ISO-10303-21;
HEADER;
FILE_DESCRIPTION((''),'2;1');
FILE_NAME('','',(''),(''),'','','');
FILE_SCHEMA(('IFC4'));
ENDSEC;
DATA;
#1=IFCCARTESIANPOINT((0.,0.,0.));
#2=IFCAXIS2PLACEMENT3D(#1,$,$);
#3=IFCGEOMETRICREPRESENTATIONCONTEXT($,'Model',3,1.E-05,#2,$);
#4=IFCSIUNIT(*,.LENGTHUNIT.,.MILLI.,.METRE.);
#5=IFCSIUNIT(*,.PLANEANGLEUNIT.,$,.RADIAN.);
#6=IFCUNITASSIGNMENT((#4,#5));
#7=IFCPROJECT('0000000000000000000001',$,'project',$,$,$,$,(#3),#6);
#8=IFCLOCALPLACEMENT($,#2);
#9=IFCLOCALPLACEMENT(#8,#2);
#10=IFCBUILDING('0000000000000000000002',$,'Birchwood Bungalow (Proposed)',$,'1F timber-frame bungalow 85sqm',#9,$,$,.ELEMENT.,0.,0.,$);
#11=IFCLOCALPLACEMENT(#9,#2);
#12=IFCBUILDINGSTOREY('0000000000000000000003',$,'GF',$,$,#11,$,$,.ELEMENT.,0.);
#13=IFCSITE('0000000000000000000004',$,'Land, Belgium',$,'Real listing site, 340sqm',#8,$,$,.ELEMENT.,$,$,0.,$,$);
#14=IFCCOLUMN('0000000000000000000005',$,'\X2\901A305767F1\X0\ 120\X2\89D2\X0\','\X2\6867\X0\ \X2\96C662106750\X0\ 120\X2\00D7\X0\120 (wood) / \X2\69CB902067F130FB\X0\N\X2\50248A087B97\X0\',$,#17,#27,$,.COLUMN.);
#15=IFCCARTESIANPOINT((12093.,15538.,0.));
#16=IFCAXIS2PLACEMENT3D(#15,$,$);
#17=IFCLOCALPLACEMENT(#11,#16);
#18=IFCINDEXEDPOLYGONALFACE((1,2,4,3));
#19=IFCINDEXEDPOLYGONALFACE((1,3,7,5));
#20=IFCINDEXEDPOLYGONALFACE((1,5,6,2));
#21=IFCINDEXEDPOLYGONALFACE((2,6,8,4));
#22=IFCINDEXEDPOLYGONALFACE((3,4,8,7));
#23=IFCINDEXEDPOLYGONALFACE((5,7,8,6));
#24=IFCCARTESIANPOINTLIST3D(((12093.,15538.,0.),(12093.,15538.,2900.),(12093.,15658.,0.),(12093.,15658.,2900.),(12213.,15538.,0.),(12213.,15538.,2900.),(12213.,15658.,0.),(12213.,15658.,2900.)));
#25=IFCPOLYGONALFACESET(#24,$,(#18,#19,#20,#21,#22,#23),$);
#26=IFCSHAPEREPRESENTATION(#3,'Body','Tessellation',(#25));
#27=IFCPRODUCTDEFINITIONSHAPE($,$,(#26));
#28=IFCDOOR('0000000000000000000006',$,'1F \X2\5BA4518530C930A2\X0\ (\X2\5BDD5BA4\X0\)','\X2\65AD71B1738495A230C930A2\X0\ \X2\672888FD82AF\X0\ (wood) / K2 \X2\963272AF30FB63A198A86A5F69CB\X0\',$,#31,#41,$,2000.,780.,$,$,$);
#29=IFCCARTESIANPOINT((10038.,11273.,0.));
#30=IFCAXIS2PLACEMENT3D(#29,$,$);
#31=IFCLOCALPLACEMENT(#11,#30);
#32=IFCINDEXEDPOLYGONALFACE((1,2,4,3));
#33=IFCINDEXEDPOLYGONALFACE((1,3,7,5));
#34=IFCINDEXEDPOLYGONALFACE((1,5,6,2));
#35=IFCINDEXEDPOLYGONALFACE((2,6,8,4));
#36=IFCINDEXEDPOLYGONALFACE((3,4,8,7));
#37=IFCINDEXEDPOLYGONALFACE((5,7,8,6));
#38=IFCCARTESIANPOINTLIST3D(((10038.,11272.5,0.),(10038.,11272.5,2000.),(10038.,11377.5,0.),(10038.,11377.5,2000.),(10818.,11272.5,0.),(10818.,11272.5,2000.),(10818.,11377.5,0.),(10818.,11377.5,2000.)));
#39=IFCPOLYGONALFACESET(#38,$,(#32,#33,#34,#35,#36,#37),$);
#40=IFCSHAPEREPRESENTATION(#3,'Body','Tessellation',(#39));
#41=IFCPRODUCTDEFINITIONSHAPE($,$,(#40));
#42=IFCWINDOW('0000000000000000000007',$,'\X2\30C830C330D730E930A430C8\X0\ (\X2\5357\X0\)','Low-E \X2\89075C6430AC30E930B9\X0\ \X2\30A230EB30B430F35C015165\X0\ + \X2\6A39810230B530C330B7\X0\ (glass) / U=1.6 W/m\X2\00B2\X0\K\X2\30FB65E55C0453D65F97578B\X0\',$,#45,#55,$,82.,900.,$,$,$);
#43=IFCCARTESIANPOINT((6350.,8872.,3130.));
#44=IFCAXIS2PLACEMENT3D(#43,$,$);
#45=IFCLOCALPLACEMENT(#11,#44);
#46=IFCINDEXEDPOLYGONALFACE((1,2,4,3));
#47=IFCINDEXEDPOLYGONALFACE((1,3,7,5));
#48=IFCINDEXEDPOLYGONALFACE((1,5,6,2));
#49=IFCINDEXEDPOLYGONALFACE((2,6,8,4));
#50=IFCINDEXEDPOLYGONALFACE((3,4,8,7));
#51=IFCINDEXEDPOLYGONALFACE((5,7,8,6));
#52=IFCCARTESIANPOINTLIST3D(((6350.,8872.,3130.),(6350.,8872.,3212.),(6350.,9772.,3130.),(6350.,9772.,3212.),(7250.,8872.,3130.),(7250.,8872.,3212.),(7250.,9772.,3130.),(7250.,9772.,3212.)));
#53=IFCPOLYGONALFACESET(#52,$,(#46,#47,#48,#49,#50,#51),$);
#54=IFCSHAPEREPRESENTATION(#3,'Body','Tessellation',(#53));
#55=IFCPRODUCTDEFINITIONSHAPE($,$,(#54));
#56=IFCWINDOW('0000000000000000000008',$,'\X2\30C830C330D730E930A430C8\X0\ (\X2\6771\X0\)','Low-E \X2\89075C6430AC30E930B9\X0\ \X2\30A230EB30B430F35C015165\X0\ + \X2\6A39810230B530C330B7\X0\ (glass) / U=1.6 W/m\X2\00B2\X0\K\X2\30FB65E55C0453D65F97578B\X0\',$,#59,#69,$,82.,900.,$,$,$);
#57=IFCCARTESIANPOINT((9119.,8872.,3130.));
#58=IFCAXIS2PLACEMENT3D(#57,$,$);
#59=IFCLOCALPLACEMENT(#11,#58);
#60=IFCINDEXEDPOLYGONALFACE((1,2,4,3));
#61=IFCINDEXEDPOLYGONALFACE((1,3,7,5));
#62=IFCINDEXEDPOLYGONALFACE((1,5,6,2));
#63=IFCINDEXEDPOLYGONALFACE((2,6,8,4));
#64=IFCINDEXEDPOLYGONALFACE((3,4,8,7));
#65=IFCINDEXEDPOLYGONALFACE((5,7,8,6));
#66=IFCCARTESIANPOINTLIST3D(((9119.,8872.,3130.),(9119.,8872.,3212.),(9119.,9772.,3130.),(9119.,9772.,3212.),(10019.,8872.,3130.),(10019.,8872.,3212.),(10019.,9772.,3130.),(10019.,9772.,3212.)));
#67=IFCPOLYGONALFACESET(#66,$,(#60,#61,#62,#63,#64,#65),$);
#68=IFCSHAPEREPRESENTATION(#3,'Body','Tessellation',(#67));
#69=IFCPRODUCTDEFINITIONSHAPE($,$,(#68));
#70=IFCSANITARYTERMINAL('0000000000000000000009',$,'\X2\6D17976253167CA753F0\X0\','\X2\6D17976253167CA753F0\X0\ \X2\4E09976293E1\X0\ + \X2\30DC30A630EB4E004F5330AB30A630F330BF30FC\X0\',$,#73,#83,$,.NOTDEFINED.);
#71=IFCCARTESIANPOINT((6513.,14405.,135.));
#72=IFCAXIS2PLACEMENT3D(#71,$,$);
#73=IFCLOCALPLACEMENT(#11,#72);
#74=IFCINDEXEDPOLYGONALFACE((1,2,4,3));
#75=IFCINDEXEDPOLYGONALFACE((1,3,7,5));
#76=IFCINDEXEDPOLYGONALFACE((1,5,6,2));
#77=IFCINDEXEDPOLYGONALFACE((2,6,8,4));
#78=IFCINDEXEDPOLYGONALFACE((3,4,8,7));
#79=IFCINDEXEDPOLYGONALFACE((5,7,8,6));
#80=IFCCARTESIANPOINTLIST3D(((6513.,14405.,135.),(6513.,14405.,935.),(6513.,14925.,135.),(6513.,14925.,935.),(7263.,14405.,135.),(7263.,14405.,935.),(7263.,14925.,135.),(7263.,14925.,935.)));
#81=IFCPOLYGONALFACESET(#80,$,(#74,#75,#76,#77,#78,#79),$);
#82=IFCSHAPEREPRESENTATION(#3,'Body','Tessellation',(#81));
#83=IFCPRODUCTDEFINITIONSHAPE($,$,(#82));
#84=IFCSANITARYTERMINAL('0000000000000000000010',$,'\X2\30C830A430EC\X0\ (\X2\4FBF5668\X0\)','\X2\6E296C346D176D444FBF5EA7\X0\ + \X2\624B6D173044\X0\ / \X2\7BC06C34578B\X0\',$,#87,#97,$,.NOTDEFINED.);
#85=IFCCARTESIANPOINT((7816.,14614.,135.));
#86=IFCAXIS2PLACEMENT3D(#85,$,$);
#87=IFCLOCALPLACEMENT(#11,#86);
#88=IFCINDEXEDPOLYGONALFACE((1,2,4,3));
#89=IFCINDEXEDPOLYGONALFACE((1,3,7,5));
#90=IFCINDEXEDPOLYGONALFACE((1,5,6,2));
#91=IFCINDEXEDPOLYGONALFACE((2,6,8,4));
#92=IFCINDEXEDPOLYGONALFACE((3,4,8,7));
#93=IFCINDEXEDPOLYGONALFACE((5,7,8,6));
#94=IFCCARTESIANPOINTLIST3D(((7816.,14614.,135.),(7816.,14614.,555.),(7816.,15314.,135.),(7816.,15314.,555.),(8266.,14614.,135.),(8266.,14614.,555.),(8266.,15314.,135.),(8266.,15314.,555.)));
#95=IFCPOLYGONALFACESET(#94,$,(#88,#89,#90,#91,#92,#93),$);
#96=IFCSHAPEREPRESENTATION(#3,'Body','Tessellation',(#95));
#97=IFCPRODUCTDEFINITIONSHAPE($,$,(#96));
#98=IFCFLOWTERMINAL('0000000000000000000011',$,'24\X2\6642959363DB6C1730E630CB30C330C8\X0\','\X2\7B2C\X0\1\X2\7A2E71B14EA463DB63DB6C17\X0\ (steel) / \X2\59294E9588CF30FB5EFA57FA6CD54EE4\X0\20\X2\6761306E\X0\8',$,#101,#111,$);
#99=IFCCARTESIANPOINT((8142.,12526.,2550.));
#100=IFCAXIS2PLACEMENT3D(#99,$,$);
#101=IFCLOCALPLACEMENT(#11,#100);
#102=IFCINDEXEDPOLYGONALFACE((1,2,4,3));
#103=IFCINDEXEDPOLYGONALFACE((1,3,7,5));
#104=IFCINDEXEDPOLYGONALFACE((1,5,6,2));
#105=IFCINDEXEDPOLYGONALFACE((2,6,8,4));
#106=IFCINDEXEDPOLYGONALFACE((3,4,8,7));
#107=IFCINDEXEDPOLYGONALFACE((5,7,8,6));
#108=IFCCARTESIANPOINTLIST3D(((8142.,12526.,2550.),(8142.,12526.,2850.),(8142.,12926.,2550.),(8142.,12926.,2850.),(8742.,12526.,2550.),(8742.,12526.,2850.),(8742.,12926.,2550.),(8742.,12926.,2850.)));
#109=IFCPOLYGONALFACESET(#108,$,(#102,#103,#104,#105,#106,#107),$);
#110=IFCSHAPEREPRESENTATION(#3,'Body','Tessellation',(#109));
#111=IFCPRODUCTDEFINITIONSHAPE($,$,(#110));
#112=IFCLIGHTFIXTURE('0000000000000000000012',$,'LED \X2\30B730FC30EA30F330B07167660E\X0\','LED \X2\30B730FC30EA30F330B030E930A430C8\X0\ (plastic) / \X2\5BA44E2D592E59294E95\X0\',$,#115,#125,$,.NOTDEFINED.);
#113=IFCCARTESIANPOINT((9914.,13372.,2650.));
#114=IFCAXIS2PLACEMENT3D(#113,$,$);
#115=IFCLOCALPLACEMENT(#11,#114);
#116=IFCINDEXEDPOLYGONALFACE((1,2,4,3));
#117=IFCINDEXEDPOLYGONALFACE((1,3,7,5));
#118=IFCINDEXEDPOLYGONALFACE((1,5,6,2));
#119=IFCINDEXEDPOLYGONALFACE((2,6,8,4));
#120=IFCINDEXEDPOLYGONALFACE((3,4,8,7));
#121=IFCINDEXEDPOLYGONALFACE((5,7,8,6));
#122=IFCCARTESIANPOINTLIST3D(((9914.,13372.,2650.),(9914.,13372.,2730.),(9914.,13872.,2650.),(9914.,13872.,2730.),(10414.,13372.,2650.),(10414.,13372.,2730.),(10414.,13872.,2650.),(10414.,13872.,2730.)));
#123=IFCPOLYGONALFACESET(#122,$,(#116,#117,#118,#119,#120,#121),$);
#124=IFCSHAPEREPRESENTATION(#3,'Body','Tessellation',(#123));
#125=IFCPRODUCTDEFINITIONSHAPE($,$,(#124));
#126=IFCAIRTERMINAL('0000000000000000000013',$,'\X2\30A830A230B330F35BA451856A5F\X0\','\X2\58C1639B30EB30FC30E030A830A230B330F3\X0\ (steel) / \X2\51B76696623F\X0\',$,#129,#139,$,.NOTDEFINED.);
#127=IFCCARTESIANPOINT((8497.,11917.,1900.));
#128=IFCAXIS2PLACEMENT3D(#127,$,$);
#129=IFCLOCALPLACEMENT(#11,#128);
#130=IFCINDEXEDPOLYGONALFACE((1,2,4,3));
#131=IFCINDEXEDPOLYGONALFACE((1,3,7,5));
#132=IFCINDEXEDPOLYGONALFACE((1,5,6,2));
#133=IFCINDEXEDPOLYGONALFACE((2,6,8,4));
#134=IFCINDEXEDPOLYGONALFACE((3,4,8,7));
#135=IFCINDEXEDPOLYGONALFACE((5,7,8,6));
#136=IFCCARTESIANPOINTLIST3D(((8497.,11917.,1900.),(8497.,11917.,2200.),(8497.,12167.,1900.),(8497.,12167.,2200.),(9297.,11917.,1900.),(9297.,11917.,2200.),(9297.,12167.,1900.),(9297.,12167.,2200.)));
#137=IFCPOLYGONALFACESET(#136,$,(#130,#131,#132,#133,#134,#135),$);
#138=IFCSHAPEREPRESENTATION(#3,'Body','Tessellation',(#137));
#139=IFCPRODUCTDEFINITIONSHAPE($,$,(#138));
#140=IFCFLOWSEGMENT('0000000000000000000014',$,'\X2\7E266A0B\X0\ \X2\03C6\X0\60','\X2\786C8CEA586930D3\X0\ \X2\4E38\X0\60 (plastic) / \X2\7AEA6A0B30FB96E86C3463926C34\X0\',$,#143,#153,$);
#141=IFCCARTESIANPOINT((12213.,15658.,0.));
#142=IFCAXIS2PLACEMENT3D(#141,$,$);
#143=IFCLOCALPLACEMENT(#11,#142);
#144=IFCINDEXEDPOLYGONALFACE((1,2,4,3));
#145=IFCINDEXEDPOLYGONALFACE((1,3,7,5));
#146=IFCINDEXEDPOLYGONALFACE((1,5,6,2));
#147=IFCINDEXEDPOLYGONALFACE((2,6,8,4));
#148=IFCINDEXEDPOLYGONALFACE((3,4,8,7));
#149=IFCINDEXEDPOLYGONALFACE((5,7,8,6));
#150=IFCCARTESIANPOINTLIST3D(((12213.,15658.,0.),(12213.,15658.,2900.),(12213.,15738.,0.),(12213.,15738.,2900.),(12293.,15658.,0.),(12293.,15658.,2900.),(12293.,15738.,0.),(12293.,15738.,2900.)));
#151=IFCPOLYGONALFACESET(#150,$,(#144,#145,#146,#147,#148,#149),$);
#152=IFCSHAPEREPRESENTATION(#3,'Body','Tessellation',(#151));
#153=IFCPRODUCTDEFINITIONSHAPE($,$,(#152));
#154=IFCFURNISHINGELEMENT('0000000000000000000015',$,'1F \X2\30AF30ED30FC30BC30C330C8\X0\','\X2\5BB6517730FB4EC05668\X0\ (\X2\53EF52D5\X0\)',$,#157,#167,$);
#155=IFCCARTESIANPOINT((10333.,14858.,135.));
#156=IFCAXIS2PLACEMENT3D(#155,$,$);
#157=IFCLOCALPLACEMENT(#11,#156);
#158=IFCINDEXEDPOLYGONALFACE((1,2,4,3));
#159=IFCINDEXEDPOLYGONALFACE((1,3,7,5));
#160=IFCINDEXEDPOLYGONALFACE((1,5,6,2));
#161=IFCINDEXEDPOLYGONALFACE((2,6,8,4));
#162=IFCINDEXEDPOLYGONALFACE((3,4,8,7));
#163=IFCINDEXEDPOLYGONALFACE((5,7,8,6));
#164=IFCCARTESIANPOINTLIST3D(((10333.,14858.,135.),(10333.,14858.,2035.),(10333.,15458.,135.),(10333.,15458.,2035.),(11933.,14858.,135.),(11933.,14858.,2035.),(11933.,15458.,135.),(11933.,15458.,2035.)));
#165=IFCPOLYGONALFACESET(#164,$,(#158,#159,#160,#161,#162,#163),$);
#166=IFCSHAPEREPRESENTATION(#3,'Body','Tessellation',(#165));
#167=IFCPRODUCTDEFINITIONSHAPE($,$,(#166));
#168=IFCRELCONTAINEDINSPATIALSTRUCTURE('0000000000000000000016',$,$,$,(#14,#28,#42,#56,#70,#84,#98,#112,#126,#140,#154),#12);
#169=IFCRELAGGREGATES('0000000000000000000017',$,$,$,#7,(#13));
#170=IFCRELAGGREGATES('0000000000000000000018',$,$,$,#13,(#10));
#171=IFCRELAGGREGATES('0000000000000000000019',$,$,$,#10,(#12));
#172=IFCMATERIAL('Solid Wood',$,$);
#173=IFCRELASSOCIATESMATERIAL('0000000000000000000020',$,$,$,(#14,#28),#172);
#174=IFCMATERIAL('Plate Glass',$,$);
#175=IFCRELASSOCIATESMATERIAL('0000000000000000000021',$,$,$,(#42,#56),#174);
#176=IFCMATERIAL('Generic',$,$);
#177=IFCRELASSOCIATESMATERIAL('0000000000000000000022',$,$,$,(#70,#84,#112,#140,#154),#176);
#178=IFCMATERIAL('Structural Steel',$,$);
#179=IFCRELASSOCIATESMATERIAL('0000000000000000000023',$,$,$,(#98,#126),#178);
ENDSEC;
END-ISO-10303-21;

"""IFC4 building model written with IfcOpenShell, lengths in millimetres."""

from ifc_helpers import new_model, si_unit, frame, frame_2d, origin, place, context, project, spatial, rectangle, extrude, material, element, save


model = new_model("IFC4")

# Units and contexts
model_context = context("Model", 3, precision=1e-05, world=origin())
ifc_project = project(units=[si_unit("LENGTHUNIT", "METRE", prefix="MILLI"), si_unit("PLANEANGLEUNIT", "RADIAN")], contexts=[model_context])

# Site, building, storey
site_placement = place(None, origin())
site = spatial("IfcSite", under=ifc_project, at=site_placement, Name="Land, Belgium", ObjectType="Real listing site, 340sqm", CompositionType="ELEMENT", RefElevation=0.0)
building_placement = place(site_placement, origin())
building = spatial("IfcBuilding", under=site, at=building_placement, Name="Birchwood Bungalow (Proposed)", ObjectType="1F timber-frame bungalow 85sqm", CompositionType="ELEMENT", ElevationOfRefHeight=0.0, ElevationOfTerrain=0.0)
storey_placement = place(building_placement, origin())
storey = spatial("IfcBuildingStorey", under=building, at=storey_placement, Name="GF", CompositionType="ELEMENT", Elevation=0.0)

# Column
ifc_material_1 = material(Name="Solid Wood")
column_1_placement = place(storey_placement, frame((12093.0, 15538.0, 0.0)))
element("IfcColumn", 1, at=column_1_placement, inside=storey, material=ifc_material_1, Name="通し柱 120角", Description="桧 集成材 120×120 (wood) / 構造柱・N値計算", PredefinedType="COLUMN", context=model_context, shape_type="SweptSolid", body=[
    extrude(rectangle(XDim=120.0, YDim=120.0, at=frame_2d((60.0, 60.0))), frame((12093.0, 15538.0, 0.0)), (0.0, 0.0, 1.0), 2900.0),
])

# Door
door_placement = place(storey_placement, frame((10038.0, 11273.0, 0.0)))
element("IfcDoor", 2, at=door_placement, inside=storey, material=ifc_material_1, Name="1F 室内ドア (寝室)", Description="断熱玄関ドア 木製芯 (wood) / K2 防犯・採風機構", OverallHeight=2000.0, OverallWidth=780.0, context=model_context, shape_type="SweptSolid", body=[
    extrude(rectangle(XDim=780.0, YDim=105.0, at=frame_2d((390.0, 52.0))), frame((10038.0, 11273.0, 0.0)), (0.0, 0.0, 1.0), 2000.0),
])

# Windows
ifc_material_2 = material(Name="Plate Glass")
window_1_placement = place(storey_placement, frame((6350.0, 8872.0, 3130.0)))
element("IfcWindow", 3, at=window_1_placement, inside=storey, material=ifc_material_2, Name="トップライト (南)", Description="Low-E 複層ガラス アルゴン封入 + 樹脂サッシ (glass) / U=1.6 W/m²K・日射取得型", OverallHeight=82.0, OverallWidth=900.0, context=model_context, shape_type="SweptSolid", body=[
    extrude(rectangle(XDim=900.0, YDim=900.0, at=frame_2d((450.0, 450.0))), frame((6350.0, 8872.0, 3130.0)), (0.0, 0.0, 1.0), 82.0),
])
window_2_placement = place(storey_placement, frame((9119.0, 8872.0, 3130.0)))
element("IfcWindow", 4, at=window_2_placement, inside=storey, material=ifc_material_2, Name="トップライト (東)", Description="Low-E 複層ガラス アルゴン封入 + 樹脂サッシ (glass) / U=1.6 W/m²K・日射取得型", OverallHeight=82.0, OverallWidth=900.0, context=model_context, shape_type="SweptSolid", body=[
    extrude(rectangle(XDim=900.0, YDim=900.0, at=frame_2d((450.0, 450.0))), frame((9119.0, 8872.0, 3130.0)), (0.0, 0.0, 1.0), 82.0),
])

# Sanitary terminals
ifc_material_3 = material(Name="Generic")
sanitary_terminal_1_placement = place(storey_placement, frame((6513.0, 14405.0, 135.0)))
element("IfcSanitaryTerminal", 5, at=sanitary_terminal_1_placement, inside=storey, material=ifc_material_3, Name="洗面化粧台", Description="洗面化粧台 三面鏡 + ボウル一体カウンター", PredefinedType="NOTDEFINED", context=model_context, shape_type="SweptSolid", body=[
    extrude(rectangle(XDim=750.0, YDim=520.0, at=frame_2d((375.0, 260.0))), frame((6513.0, 14405.0, 135.0)), (0.0, 0.0, 1.0), 800.0),
])
sanitary_terminal_2_placement = place(storey_placement, frame((7816.0, 14614.0, 135.0)))
element("IfcSanitaryTerminal", 6, at=sanitary_terminal_2_placement, inside=storey, material=ifc_material_3, Name="トイレ (便器)", Description="温水洗浄便座 + 手洗い / 節水型", PredefinedType="NOTDEFINED", context=model_context, shape_type="SweptSolid", body=[
    extrude(rectangle(XDim=450.0, YDim=700.0, at=frame_2d((225.0, 350.0))), frame((7816.0, 14614.0, 135.0)), (0.0, 0.0, 1.0), 420.0),
])

# Flow terminal
ifc_material_4 = material(Name="Structural Steel")
flow_terminal_placement = place(storey_placement, frame((8142.0, 12526.0, 2550.0)))
element("IfcFlowTerminal", 7, at=flow_terminal_placement, inside=storey, material=ifc_material_4, Name="24時間換気ユニット", Description="第1種熱交換換気 (steel) / 天井裏・建基法令20条の8", context=model_context, shape_type="SweptSolid", body=[
    extrude(rectangle(XDim=600.0, YDim=400.0, at=frame_2d((300.0, 200.0))), frame((8142.0, 12526.0, 2550.0)), (0.0, 0.0, 1.0), 300.0),
])

# Light fixture
light_fixture_placement = place(storey_placement, frame((9914.0, 13372.0, 2650.0)))
element("IfcLightFixture", 8, at=light_fixture_placement, inside=storey, material=ifc_material_3, Name="LED シーリング照明", Description="LED シーリングライト (plastic) / 室中央天井", PredefinedType="NOTDEFINED", context=model_context, shape_type="SweptSolid", body=[
    extrude(rectangle(XDim=500.0, YDim=500.0, at=frame_2d((250.0, 250.0))), frame((9914.0, 13372.0, 2650.0)), (0.0, 0.0, 1.0), 80.0),
])

# Air terminal
air_terminal_placement = place(storey_placement, frame((8497.0, 11917.0, 1900.0)))
element("IfcAirTerminal", 9, at=air_terminal_placement, inside=storey, material=ifc_material_4, Name="エアコン室内機", Description="壁掛ルームエアコン (steel) / 冷暖房", PredefinedType="NOTDEFINED", context=model_context, shape_type="SweptSolid", body=[
    extrude(rectangle(XDim=800.0, YDim=250.0, at=frame_2d((400.0, 125.0))), frame((8497.0, 11917.0, 1900.0)), (0.0, 0.0, 1.0), 300.0),
])

# Flow segment
flow_segment_placement = place(storey_placement, frame((12213.0, 15658.0, 0.0)))
element("IfcFlowSegment", 10, at=flow_segment_placement, inside=storey, material=ifc_material_3, Name="縦樋 φ60", Description="硬質塩ビ 丸60 (plastic) / 竪樋・雨水排水", context=model_context, shape_type="SweptSolid", body=[
    extrude(rectangle(XDim=80.0, YDim=80.0, at=frame_2d((40.0, 40.0))), frame((12213.0, 15658.0, 0.0)), (0.0, 0.0, 1.0), 2900.0),
])

# Furnishing element
furnishing_placement = place(storey_placement, frame((10333.0, 14858.0, 135.0)))
element("IfcFurnishingElement", 11, at=furnishing_placement, inside=storey, material=ifc_material_3, Name="1F クローゼット", Description="家具・什器 (可動)", context=model_context, shape_type="SweptSolid", body=[
    extrude(rectangle(XDim=1600.0, YDim=600.0, at=frame_2d((800.0, 300.0))), frame((10333.0, 14858.0, 135.0)), (0.0, 0.0, 1.0), 1900.0),
])

save(model, "model.ifc")
